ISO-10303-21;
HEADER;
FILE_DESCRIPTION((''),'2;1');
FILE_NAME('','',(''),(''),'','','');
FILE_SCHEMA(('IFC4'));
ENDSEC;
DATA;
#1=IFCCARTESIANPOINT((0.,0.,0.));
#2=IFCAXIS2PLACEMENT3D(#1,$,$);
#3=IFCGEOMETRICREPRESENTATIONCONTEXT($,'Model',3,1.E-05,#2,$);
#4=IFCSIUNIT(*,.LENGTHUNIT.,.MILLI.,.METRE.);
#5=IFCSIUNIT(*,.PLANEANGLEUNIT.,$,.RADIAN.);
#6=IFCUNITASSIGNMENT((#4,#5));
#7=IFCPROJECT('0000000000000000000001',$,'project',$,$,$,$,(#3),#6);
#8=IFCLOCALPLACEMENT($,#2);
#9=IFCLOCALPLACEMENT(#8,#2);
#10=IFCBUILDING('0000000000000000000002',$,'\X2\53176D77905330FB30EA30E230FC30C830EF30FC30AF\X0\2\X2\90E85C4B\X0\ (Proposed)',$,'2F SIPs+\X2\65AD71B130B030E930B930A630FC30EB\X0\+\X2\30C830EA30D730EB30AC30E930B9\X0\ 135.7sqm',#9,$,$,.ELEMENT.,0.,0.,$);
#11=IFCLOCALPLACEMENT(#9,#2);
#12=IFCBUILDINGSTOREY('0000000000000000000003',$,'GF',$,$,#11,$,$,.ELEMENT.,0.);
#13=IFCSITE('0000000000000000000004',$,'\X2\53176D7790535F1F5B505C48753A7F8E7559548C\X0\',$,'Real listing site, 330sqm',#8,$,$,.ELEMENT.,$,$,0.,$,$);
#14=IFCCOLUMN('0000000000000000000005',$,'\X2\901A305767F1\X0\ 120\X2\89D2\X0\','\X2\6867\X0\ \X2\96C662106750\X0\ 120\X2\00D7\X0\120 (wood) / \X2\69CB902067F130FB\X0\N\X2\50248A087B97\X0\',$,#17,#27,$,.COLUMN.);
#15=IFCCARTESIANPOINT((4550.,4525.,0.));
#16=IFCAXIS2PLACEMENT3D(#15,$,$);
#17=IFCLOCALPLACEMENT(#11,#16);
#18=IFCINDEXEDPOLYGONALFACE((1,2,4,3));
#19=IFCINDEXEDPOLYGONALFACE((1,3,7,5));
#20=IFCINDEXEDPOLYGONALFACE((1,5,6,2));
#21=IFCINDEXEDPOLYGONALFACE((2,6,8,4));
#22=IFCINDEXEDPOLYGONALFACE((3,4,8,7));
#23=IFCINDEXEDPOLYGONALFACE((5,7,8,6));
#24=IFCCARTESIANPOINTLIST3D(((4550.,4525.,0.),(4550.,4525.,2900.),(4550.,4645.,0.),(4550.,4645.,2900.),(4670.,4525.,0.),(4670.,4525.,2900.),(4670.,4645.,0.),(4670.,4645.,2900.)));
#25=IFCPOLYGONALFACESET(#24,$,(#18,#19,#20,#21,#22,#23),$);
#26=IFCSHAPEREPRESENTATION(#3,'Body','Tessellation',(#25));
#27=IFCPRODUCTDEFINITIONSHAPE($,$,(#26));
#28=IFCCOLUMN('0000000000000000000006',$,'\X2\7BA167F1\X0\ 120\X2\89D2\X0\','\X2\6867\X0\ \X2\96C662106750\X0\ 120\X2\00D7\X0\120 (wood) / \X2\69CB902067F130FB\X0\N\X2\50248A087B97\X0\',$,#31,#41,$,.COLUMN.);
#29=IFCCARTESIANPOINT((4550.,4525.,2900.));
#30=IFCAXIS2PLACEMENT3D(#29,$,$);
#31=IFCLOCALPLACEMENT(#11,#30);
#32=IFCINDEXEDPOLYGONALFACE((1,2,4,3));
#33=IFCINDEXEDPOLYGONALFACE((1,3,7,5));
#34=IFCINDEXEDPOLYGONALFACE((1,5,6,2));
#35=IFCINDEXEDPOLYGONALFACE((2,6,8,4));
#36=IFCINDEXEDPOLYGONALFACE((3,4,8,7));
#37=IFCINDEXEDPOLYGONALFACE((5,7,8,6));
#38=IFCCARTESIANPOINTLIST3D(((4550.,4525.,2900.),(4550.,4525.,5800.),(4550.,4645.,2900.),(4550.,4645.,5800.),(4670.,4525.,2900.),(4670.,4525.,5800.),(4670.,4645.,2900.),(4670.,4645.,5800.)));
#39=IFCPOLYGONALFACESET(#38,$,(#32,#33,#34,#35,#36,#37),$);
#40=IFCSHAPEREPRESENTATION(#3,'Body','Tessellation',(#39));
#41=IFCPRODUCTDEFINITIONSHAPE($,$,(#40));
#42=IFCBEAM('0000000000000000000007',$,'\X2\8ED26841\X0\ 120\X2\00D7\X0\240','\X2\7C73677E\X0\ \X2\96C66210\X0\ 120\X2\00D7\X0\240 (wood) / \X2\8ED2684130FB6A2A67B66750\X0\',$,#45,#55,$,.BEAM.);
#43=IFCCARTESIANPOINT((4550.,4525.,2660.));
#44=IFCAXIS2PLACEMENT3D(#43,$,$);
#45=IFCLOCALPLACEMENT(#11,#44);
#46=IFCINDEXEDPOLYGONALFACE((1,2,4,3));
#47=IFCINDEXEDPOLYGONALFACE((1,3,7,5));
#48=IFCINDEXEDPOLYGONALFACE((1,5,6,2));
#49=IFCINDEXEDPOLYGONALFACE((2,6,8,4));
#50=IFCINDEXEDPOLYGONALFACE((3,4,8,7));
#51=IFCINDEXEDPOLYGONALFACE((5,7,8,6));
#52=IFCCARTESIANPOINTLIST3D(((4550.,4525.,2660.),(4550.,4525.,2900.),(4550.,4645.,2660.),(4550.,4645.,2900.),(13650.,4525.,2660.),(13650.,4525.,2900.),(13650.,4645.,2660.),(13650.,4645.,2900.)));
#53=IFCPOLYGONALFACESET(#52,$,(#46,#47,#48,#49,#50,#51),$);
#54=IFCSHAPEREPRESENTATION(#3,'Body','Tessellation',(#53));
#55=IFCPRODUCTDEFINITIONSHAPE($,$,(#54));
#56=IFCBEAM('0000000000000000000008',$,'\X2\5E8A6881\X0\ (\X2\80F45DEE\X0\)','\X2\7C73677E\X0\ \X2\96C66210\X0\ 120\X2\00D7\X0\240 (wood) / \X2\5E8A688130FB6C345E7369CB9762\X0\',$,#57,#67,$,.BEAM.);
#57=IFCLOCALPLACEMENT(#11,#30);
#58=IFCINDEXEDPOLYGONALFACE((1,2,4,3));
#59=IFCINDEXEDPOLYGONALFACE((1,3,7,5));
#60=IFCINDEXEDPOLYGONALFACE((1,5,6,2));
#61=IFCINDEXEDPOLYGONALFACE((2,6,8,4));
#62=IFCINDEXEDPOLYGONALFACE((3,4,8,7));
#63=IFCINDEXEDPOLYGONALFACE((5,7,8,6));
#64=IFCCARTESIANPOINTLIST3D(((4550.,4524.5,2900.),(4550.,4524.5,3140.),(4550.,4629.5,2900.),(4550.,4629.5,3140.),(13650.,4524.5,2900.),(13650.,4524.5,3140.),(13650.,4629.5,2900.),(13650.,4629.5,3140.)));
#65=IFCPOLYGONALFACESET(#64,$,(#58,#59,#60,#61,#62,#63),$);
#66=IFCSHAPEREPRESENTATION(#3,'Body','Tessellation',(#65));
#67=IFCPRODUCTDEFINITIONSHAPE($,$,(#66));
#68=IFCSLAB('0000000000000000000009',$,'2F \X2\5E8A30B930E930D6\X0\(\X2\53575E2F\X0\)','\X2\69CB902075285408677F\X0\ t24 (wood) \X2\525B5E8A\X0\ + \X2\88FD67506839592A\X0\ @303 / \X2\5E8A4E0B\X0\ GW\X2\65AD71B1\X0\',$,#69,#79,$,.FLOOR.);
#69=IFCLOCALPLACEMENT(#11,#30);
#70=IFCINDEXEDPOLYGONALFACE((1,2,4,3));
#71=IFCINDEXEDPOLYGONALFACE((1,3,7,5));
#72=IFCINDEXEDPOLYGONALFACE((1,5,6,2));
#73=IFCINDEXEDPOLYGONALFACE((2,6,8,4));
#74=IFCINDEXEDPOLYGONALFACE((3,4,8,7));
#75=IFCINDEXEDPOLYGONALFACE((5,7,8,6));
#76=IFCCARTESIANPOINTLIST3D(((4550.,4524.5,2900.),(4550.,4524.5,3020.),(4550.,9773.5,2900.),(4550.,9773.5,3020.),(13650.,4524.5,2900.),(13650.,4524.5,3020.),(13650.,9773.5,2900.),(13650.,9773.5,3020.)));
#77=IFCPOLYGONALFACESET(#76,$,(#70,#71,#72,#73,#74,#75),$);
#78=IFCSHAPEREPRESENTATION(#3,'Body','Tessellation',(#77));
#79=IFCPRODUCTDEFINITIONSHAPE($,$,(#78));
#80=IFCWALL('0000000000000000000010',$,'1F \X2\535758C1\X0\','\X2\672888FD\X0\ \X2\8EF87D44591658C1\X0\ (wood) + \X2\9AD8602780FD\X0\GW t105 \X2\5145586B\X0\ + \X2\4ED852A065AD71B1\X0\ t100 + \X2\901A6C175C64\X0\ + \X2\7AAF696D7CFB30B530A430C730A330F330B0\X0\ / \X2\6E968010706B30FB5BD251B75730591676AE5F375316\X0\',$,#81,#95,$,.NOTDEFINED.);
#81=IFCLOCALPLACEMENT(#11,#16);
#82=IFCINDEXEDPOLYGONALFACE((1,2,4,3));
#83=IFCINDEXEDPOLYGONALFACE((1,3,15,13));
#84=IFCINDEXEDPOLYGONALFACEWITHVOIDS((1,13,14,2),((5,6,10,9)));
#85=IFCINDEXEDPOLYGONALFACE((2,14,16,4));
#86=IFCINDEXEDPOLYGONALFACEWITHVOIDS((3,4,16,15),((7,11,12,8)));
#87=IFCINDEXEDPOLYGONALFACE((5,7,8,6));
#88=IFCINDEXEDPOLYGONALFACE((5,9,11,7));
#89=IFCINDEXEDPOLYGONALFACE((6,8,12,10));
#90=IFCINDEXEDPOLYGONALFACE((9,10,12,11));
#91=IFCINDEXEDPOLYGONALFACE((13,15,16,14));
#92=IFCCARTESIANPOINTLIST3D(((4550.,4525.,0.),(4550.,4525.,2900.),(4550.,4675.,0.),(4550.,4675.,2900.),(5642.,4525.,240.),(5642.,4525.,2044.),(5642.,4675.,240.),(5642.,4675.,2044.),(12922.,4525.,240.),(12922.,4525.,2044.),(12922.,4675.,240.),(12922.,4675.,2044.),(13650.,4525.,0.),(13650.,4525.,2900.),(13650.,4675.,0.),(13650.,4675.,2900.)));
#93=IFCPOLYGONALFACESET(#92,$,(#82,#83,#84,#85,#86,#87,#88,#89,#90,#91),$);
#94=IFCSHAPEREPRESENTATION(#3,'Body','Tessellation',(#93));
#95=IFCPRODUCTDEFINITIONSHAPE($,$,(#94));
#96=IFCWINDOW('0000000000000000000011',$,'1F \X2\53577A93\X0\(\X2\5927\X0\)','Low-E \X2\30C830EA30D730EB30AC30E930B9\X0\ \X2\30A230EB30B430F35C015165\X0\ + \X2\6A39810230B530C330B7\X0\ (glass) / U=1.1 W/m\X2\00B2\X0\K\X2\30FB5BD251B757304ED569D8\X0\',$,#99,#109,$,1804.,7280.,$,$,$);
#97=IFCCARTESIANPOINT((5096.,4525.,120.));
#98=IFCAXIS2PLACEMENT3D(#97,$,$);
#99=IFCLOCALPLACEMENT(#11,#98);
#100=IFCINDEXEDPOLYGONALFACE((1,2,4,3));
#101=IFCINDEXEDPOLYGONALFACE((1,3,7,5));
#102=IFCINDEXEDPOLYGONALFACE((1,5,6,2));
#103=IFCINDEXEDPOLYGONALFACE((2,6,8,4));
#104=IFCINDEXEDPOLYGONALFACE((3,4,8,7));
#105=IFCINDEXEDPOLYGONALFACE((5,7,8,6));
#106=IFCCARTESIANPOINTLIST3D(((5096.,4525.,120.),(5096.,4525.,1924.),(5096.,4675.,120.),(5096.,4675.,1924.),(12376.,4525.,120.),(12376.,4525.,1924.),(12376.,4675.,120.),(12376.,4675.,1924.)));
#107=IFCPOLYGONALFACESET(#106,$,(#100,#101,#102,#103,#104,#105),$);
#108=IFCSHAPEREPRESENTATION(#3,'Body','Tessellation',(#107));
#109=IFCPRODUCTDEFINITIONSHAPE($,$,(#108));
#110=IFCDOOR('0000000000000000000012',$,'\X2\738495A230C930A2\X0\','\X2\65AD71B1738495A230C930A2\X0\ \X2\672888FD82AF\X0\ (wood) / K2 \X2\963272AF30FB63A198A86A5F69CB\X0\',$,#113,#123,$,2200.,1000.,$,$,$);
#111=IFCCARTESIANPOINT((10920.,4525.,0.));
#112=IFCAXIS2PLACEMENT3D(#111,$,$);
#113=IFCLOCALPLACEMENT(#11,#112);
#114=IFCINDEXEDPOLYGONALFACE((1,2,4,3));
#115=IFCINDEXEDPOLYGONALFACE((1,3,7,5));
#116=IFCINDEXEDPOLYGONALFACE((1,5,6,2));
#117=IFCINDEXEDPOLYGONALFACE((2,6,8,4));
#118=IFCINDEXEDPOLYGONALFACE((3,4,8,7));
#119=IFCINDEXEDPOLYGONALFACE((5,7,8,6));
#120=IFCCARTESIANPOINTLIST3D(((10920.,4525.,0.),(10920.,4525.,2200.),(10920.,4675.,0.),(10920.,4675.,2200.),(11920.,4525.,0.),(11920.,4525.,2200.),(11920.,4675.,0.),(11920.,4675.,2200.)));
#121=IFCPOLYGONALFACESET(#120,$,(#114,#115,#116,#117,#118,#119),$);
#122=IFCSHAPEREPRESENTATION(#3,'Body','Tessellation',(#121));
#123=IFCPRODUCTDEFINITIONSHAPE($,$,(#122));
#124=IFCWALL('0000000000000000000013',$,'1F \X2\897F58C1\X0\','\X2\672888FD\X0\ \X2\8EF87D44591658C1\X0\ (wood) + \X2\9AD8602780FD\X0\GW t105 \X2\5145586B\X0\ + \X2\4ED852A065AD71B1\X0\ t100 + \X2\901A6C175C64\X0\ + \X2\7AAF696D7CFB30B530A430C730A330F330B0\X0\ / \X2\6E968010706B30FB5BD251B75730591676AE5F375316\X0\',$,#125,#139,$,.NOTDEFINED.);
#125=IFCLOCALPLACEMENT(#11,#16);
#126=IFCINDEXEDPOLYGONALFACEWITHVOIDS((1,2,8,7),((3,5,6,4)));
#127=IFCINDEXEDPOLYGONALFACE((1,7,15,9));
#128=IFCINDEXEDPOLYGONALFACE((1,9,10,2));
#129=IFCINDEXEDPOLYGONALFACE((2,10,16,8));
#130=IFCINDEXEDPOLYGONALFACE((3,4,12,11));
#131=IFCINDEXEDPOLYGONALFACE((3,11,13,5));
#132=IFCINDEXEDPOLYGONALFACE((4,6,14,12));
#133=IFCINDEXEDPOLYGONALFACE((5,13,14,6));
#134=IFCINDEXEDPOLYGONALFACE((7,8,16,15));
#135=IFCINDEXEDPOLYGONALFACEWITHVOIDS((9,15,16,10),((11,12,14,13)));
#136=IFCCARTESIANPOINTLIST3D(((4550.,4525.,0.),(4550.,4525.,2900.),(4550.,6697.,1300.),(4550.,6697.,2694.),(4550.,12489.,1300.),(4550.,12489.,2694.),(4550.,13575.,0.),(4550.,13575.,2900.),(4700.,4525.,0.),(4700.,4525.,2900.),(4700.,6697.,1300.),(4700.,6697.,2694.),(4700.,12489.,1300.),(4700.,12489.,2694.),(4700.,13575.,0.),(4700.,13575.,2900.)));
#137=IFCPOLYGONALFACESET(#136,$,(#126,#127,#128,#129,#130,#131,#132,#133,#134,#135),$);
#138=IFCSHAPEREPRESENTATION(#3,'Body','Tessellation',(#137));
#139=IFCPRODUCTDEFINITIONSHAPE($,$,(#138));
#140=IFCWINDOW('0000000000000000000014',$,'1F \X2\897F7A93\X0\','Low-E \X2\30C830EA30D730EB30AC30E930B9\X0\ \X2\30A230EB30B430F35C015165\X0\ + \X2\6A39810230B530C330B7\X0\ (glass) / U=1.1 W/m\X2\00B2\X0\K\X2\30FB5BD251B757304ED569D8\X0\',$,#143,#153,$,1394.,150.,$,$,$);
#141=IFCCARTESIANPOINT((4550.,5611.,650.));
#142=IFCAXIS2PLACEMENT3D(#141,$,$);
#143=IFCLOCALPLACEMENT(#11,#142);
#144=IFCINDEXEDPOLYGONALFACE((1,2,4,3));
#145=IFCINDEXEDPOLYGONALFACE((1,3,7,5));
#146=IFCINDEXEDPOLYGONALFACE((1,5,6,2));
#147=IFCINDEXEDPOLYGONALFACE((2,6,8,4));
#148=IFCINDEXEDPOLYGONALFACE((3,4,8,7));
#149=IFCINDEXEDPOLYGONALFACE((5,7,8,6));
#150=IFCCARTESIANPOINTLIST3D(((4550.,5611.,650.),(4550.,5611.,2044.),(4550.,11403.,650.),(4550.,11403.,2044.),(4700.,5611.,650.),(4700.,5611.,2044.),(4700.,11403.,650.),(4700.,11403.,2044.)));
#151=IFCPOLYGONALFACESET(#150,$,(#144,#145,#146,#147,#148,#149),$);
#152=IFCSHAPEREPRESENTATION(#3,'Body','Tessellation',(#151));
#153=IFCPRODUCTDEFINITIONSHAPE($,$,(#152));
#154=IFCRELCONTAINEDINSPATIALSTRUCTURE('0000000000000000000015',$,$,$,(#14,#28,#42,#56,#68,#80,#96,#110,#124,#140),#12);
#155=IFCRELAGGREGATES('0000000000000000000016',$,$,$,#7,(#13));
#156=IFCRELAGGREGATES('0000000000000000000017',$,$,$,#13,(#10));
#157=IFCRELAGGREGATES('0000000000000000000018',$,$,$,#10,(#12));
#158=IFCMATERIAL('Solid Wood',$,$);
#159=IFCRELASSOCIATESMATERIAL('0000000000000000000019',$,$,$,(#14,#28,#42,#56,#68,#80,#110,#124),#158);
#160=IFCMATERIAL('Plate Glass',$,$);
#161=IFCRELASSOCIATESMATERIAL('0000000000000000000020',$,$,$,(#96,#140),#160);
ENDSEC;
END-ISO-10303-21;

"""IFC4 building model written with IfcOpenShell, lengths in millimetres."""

from ifc_helpers import new_model, si_unit, frame, frame_2d, origin, place, context, project, spatial, rectangle, extrude, material, element, fill, save


model = new_model("IFC4")

# Units and contexts
model_context = context("Model", 3, precision=1e-05, world=origin())
ifc_project = project(units=[si_unit("LENGTHUNIT", "METRE", prefix="MILLI"), si_unit("PLANEANGLEUNIT", "RADIAN")], contexts=[model_context])

# Site, building, storey
site_placement = place(None, origin())
site = spatial("IfcSite", under=ifc_project, at=site_placement, Name="北海道弟子屈町美留和", ObjectType="Real listing site, 330sqm", CompositionType="ELEMENT", RefElevation=0.0)
building_placement = place(site_placement, origin())
building = spatial("IfcBuilding", under=site, at=building_placement, Name="北海道・リモートワーク2部屋 (Proposed)", ObjectType="2F SIPs+断熱グラスウール+トリプルガラス 135.7sqm", CompositionType="ELEMENT", ElevationOfRefHeight=0.0, ElevationOfTerrain=0.0)
storey_placement = place(building_placement, origin())
storey = spatial("IfcBuildingStorey", under=building, at=storey_placement, Name="GF", CompositionType="ELEMENT", Elevation=0.0)

# Columns
ifc_material_1 = material(Name="Solid Wood")
column_1_placement = place(storey_placement, frame((4550.0, 4525.0, 0.0)))
element("IfcColumn", 1, at=column_1_placement, inside=storey, material=ifc_material_1, Name="通し柱 120角", Description="桧 集成材 120×120 (wood) / 構造柱・N値計算", PredefinedType="COLUMN", context=model_context, shape_type="SweptSolid", body=[
    extrude(rectangle(XDim=120.0, YDim=120.0, at=frame_2d((60.0, 60.0))), frame((4550.0, 4525.0, 0.0)), (0.0, 0.0, 1.0), 2900.0),
])
column_2_placement = place(storey_placement, frame((4550.0, 4525.0, 2900.0)))
element("IfcColumn", 2, at=column_2_placement, inside=storey, material=ifc_material_1, Name="管柱 120角", Description="桧 集成材 120×120 (wood) / 構造柱・N値計算", PredefinedType="COLUMN", context=model_context, shape_type="SweptSolid", body=[
    extrude(rectangle(XDim=120.0, YDim=120.0, at=frame_2d((60.0, 60.0))), frame((4550.0, 4525.0, 2900.0)), (0.0, 0.0, 1.0), 2900.0),
])

# Beams
beam_1_placement = place(storey_placement, frame((4550.0, 4525.0, 2660.0)))
element("IfcBeam", 3, at=beam_1_placement, inside=storey, material=ifc_material_1, Name="軒桁 120×240", Description="米松 集成 120×240 (wood) / 軒桁・横架材", PredefinedType="BEAM", context=model_context, shape_type="SweptSolid", body=[
    extrude(rectangle(XDim=9100.0, YDim=120.0, at=frame_2d((4550.0, 60.0))), frame((4550.0, 4525.0, 2660.0)), (0.0, 0.0, 1.0), 240.0),
])
beam_2_placement = place(storey_placement, frame((4550.0, 4525.0, 2900.0)))
element("IfcBeam", 4, at=beam_2_placement, inside=storey, material=ifc_material_1, Name="床梁 (胴差)", Description="米松 集成 120×240 (wood) / 床梁・水平構面", PredefinedType="BEAM", context=model_context, shape_type="SweptSolid", body=[
    extrude(rectangle(XDim=9100.0, YDim=105.0, at=frame_2d((4550.0, 52.0))), frame((4550.0, 4525.0, 2900.0)), (0.0, 0.0, 1.0), 240.0),
])

# Slab
slab_1_placement = place(storey_placement, frame((4550.0, 4525.0, 2900.0)))
element("IfcSlab", 5, at=slab_1_placement, inside=storey, material=ifc_material_1, Name="2F 床スラブ(南帯)", Description="構造用合板 t24 (wood) 剛床 + 製材根太 @303 / 床下 GW断熱", PredefinedType="FLOOR", context=model_context, shape_type="SweptSolid", body=[
    extrude(rectangle(XDim=9100.0, YDim=5249.0, at=frame_2d((4550.0, 2624.0))), frame((4550.0, 4525.0, 2900.0)), (0.0, 0.0, 1.0), 120.0),
])

# Wall, openings, window, door
wall_1_placement = place(storey_placement, frame((4550.0, 4525.0, 0.0)))
wall_1 = element("IfcWall", 6, at=wall_1_placement, inside=storey, material=ifc_material_1, Name="1F 南壁", Description="木製 軸組外壁 (wood) + 高性能GW t105 充填 + 付加断熱 t100 + 通気層 + 窯業系サイディング / 準耐火・寒冷地外皮強化", PredefinedType="NOTDEFINED", context=model_context, shape_type="SweptSolid", body=[
    extrude(rectangle(XDim=9100.0, YDim=150.0, at=frame_2d((4550.0, 75.0))), frame((4550.0, 4525.0, 0.0)), (0.0, 0.0, 1.0), 2900.0),
])
opening_1_placement = place(storey_placement, frame((5096.0, 4525.0, 120.0)))
opening_1 = element("IfcOpeningElement", 7, at=opening_1_placement, cuts=wall_1, PredefinedType="NOTDEFINED", context=model_context, shape_type="SweptSolid", body=[
    extrude(rectangle(XDim=7280.0, YDim=150.0, at=frame_2d((3640.0, 75.0))), frame((5096.0, 4525.0, 120.0)), (0.0, 0.0, 1.0), 1804.0),
])
opening_2_placement = place(storey_placement, frame((10920.0, 4525.0, 0.0)))
opening_2 = element("IfcOpeningElement", 8, at=opening_2_placement, cuts=wall_1, PredefinedType="NOTDEFINED", context=model_context, shape_type="SweptSolid", body=[
    extrude(rectangle(XDim=1000.0, YDim=150.0, at=frame_2d((500.0, 75.0))), frame((10920.0, 4525.0, 0.0)), (0.0, 0.0, 1.0), 2200.0),
])
ifc_material_2 = material(Name="Plate Glass")
window_1_placement = place(storey_placement, frame((5096.0, 4525.0, 120.0)))
window_1 = element("IfcWindow", 9, at=window_1_placement, inside=storey, material=ifc_material_2, Name="1F 南窓(大)", Description="Low-E トリプルガラス アルゴン封入 + 樹脂サッシ (glass) / U=1.1 W/m²K・寒冷地仕様", OverallHeight=1804.0, OverallWidth=7280.0, context=model_context, shape_type="SweptSolid", body=[
    extrude(rectangle(XDim=7280.0, YDim=150.0, at=frame_2d((3640.0, 75.0))), frame((5096.0, 4525.0, 120.0)), (0.0, 0.0, 1.0), 1804.0),
])
fill(opening_1, window_1)
door_placement = place(storey_placement, frame((10920.0, 4525.0, 0.0)))
door = element("IfcDoor", 10, at=door_placement, inside=storey, material=ifc_material_1, Name="玄関ドア", Description="断熱玄関ドア 木製芯 (wood) / K2 防犯・採風機構", OverallHeight=2200.0, OverallWidth=1000.0, context=model_context, shape_type="SweptSolid", body=[
    extrude(rectangle(XDim=1000.0, YDim=150.0, at=frame_2d((500.0, 75.0))), frame((10920.0, 4525.0, 0.0)), (0.0, 0.0, 1.0), 2200.0),
])
fill(opening_2, door)

# Wall, opening, window
wall_2_placement = place(storey_placement, frame((4550.0, 4525.0, 0.0)))
wall_2 = element("IfcWall", 11, at=wall_2_placement, inside=storey, material=ifc_material_1, Name="1F 西壁", Description="木製 軸組外壁 (wood) + 高性能GW t105 充填 + 付加断熱 t100 + 通気層 + 窯業系サイディング / 準耐火・寒冷地外皮強化", PredefinedType="NOTDEFINED", context=model_context, shape_type="SweptSolid", body=[
    extrude(rectangle(XDim=150.0, YDim=9050.0, at=frame_2d((75.0, 4525.0))), frame((4550.0, 4525.0, 0.0)), (0.0, 0.0, 1.0), 2900.0),
])
opening_3_placement = place(storey_placement, frame((4550.0, 5611.0, 650.0)))
opening_3 = element("IfcOpeningElement", 12, at=opening_3_placement, cuts=wall_2, PredefinedType="NOTDEFINED", context=model_context, shape_type="SweptSolid", body=[
    extrude(rectangle(XDim=150.0, YDim=5792.0, at=frame_2d((75.0, 2896.0))), frame((4550.0, 5611.0, 650.0)), (0.0, 0.0, 1.0), 1394.0),
])
window_2_placement = place(storey_placement, frame((4550.0, 5611.0, 650.0)))
window_2 = element("IfcWindow", 13, at=window_2_placement, inside=storey, material=ifc_material_2, Name="1F 西窓", Description="Low-E トリプルガラス アルゴン封入 + 樹脂サッシ (glass) / U=1.1 W/m²K・寒冷地仕様", OverallHeight=1394.0, OverallWidth=150.0, context=model_context, shape_type="SweptSolid", body=[
    extrude(rectangle(XDim=150.0, YDim=5792.0, at=frame_2d((75.0, 2896.0))), frame((4550.0, 5611.0, 650.0)), (0.0, 0.0, 1.0), 1394.0),
])
fill(opening_3, window_2)

save(model, "model.ifc")
